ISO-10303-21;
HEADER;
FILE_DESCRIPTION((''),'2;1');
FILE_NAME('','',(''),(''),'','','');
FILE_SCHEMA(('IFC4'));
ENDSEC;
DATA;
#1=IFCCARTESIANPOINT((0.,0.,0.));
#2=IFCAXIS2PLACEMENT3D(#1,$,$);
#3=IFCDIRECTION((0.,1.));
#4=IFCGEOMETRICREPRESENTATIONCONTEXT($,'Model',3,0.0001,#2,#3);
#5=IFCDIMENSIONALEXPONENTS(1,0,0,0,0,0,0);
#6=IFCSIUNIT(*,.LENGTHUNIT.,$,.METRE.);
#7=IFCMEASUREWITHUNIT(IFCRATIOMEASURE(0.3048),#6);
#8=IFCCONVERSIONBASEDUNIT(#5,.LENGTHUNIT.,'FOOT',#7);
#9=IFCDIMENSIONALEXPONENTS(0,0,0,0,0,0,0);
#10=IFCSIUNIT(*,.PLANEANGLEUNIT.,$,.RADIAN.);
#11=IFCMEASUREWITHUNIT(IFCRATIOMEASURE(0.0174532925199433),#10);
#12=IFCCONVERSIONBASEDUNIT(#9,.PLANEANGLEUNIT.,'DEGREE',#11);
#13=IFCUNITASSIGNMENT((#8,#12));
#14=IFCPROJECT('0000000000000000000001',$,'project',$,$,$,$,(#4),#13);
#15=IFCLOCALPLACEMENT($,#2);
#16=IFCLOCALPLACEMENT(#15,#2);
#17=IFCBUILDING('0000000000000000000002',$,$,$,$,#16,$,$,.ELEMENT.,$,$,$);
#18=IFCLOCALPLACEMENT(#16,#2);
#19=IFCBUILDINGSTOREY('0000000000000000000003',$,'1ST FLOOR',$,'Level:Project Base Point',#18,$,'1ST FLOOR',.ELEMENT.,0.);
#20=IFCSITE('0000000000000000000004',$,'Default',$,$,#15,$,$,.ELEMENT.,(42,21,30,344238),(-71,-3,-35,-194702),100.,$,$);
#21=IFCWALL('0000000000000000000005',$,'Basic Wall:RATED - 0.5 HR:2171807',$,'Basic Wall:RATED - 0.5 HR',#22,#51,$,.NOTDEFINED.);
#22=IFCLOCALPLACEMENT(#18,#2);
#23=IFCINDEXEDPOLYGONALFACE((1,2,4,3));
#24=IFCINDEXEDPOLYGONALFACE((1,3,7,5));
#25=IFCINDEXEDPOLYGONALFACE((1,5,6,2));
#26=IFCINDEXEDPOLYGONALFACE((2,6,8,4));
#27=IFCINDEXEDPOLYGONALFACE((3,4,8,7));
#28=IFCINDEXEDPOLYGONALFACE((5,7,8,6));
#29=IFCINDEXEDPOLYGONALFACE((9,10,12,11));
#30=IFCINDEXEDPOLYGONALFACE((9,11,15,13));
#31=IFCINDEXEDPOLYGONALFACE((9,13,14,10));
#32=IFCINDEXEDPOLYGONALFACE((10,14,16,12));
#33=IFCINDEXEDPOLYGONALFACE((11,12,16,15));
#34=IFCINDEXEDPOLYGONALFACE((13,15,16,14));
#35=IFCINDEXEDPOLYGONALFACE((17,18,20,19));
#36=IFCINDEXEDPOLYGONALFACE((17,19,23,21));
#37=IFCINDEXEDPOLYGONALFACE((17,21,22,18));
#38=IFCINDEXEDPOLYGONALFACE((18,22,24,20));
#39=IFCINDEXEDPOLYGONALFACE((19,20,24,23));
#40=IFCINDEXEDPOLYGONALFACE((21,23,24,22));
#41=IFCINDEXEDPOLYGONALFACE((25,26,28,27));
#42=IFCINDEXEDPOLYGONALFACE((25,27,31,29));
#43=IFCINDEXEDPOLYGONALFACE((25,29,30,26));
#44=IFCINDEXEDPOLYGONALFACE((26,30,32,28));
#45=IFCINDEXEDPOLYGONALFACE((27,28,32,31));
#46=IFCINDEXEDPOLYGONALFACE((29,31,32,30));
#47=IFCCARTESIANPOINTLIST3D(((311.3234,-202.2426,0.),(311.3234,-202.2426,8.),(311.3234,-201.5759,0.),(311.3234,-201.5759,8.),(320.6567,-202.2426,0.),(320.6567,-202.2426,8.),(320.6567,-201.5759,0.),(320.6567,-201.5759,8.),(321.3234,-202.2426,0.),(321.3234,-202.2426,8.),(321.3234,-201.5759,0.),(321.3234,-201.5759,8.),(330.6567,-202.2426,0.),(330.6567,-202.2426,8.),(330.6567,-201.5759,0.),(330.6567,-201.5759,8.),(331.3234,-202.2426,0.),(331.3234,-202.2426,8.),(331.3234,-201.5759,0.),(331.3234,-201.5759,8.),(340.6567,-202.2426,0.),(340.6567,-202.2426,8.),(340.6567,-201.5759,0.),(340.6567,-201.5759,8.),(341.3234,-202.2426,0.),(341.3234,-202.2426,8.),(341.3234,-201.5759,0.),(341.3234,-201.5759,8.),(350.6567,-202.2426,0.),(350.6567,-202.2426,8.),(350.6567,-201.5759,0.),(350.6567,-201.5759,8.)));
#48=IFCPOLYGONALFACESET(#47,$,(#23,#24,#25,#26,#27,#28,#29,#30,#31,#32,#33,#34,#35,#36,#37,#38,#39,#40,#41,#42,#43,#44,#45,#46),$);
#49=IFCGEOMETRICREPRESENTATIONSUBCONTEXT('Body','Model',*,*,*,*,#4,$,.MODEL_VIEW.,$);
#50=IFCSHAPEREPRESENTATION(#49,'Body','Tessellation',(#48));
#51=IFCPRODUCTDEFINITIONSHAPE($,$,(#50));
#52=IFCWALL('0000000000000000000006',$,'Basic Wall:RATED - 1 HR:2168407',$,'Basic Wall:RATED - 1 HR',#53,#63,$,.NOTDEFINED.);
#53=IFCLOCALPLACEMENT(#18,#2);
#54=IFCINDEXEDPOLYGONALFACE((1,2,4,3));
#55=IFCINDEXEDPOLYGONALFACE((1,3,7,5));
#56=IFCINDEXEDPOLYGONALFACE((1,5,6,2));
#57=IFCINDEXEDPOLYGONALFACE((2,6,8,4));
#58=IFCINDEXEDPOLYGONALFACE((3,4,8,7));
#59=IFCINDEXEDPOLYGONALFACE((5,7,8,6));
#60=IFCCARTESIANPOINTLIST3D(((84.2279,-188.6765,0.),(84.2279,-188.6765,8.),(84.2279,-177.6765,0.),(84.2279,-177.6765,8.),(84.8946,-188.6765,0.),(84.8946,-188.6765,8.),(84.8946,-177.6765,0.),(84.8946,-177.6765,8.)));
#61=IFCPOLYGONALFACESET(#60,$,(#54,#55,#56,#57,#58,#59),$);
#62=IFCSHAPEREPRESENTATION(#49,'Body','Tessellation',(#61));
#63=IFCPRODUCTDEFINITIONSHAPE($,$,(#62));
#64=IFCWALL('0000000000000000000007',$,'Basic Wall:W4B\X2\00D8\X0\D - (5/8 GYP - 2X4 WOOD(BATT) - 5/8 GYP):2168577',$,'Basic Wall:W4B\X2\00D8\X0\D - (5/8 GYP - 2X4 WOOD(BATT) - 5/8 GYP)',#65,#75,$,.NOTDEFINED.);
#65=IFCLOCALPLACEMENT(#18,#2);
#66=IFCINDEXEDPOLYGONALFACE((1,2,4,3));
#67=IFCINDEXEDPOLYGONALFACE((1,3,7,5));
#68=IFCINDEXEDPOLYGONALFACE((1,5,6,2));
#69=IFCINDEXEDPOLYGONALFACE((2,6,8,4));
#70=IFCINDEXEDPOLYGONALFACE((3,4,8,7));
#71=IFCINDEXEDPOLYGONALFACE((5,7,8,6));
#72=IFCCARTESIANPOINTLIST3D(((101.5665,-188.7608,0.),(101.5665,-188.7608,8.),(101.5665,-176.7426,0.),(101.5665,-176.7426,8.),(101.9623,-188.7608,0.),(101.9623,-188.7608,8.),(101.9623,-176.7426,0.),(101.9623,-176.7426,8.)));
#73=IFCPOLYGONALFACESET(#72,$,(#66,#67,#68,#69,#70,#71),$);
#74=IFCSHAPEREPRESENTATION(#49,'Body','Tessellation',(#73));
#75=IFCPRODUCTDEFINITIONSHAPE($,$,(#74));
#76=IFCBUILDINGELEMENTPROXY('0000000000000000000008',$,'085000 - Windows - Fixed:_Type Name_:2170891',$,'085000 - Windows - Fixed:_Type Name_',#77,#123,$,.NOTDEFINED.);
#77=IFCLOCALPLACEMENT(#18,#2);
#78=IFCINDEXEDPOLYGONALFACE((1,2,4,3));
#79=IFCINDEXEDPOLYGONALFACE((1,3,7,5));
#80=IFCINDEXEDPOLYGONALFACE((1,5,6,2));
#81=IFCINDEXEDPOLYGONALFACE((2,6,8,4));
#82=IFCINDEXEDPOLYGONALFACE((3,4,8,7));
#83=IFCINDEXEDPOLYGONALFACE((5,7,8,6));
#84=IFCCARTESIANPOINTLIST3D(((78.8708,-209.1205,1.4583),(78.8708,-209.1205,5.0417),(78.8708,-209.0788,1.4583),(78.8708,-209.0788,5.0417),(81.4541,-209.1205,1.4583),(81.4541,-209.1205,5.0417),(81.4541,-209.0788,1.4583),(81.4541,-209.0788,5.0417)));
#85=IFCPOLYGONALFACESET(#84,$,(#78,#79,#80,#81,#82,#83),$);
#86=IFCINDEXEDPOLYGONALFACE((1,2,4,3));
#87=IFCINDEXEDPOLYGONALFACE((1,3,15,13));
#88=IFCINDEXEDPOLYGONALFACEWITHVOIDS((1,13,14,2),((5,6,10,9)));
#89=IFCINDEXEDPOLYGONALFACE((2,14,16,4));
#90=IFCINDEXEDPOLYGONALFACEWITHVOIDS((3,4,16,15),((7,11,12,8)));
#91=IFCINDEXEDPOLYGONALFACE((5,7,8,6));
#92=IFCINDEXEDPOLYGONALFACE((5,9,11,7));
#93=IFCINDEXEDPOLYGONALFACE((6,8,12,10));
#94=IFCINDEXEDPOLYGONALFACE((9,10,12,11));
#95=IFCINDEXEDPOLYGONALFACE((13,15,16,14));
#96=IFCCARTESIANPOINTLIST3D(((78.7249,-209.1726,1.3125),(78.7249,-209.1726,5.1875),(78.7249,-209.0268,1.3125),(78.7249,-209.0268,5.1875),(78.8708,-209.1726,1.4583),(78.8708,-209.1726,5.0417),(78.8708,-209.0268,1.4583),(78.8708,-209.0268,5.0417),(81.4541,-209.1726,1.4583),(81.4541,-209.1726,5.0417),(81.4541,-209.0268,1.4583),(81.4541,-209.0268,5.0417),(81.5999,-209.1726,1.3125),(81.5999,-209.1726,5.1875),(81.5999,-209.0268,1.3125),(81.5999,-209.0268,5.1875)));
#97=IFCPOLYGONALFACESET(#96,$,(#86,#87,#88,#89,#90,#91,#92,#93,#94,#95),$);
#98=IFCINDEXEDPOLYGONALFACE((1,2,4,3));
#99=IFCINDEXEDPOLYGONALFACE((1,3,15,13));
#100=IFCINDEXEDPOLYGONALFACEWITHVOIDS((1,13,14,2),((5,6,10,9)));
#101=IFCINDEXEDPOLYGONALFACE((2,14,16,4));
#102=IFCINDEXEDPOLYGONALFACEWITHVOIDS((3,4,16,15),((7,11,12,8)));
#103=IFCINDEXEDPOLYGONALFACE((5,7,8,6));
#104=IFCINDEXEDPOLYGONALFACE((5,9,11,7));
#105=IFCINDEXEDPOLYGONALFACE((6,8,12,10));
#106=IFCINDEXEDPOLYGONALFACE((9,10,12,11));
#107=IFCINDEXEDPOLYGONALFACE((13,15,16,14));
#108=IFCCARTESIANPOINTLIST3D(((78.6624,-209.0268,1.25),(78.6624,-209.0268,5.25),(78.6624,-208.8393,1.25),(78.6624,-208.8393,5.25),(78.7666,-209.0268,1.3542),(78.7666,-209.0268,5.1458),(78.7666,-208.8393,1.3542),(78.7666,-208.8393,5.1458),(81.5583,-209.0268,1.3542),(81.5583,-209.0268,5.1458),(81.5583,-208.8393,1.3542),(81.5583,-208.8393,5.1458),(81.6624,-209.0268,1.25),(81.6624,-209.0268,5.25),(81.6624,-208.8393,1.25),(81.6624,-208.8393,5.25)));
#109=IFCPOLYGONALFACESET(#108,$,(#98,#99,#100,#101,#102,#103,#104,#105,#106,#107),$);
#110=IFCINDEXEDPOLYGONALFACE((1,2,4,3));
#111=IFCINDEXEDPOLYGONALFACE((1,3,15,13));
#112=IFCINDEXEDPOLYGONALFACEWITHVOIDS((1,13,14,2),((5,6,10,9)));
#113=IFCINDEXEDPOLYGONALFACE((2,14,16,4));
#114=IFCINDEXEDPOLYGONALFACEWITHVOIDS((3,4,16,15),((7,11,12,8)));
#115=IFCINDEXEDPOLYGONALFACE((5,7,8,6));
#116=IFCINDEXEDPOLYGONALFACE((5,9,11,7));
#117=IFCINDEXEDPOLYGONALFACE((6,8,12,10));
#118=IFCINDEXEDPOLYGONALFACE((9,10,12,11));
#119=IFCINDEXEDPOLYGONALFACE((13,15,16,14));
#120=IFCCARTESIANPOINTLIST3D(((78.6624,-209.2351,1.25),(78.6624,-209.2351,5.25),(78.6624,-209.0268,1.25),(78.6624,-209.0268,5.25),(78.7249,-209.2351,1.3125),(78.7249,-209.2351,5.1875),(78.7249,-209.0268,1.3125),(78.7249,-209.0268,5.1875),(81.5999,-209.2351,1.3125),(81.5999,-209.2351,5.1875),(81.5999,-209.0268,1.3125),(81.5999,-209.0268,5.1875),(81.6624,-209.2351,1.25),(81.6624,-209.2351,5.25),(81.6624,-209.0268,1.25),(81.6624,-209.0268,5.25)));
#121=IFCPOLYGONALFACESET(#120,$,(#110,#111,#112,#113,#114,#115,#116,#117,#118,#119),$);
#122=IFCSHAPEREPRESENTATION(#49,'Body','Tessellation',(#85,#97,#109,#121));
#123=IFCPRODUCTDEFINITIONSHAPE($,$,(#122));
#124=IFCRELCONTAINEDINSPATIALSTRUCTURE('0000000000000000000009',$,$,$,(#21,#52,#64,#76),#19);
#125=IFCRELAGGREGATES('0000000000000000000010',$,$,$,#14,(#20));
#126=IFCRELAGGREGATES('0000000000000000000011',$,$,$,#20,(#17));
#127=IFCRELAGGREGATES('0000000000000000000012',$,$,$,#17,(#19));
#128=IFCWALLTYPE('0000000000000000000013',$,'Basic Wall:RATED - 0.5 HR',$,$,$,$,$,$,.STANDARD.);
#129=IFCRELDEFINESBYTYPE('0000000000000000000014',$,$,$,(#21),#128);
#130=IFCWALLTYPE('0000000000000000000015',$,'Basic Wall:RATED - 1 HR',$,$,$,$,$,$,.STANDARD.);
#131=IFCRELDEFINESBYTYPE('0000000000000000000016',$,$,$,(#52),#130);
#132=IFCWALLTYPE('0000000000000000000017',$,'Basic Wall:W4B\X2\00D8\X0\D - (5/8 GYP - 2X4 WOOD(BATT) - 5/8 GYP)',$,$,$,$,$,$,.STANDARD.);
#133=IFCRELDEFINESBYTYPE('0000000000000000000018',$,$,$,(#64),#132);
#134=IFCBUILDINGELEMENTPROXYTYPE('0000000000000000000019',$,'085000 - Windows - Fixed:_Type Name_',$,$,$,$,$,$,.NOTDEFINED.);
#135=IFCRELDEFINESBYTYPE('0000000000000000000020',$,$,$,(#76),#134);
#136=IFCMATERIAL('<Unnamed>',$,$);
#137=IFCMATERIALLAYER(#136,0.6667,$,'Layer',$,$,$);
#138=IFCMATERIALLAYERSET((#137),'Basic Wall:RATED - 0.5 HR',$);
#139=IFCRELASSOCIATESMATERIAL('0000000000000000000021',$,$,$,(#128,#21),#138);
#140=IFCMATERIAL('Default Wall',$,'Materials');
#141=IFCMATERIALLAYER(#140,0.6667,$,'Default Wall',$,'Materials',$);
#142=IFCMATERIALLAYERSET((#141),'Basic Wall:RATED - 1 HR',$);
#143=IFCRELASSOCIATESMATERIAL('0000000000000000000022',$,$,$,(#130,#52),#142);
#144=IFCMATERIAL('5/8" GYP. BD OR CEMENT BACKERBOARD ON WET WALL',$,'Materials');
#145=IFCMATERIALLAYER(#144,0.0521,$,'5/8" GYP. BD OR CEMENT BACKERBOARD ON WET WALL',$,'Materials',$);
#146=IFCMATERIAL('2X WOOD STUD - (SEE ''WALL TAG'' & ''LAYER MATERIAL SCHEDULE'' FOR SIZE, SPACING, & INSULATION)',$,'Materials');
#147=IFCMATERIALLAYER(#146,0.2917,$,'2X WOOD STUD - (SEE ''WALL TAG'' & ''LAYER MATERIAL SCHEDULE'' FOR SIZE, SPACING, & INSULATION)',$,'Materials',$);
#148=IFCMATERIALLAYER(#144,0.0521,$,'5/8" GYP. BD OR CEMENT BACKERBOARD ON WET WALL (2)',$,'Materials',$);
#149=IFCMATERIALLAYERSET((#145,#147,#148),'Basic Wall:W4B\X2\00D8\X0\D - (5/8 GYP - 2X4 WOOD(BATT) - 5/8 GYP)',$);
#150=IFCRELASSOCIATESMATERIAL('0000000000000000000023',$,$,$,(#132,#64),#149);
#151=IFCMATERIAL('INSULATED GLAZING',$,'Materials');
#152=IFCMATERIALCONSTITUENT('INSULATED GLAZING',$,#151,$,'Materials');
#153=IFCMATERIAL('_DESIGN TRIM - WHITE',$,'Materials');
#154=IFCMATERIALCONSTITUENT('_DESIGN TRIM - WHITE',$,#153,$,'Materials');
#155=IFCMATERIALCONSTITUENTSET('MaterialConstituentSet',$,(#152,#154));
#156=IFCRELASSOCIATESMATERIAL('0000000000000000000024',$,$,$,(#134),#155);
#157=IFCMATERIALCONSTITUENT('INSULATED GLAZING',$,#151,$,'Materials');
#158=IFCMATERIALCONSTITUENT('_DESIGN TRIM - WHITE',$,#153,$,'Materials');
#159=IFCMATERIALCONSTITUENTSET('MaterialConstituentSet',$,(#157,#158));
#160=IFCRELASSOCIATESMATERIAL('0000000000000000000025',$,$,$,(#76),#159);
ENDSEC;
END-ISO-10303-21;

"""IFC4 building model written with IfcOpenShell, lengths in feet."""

from ifc_helpers import new_model, entity, si_unit, converted_unit, direction, frame, frame_2d, origin, origin_2d_with_axis, place, context, subcontext, project, spatial, polyline, rectangle, outline, extrude, source, transform, mapped, material, layer, layer_set, layer_usage, constituent, constituent_set, type_object, type_shapes, element, save


model = new_model("IFC4")

# Units and contexts
model_context = context("Model", 3, precision=0.0001, world=origin(), true_north=direction((0.0, 1.0)))
body_context = subcontext(model_context, "Body", "Model", "MODEL_VIEW")
ifc_project = project(units=[converted_unit("LENGTHUNIT", "FOOT", entity("IfcRatioMeasure", 0.3048), si_unit("LENGTHUNIT", "METRE"), dimensions=[1, 0, 0, 0, 0, 0, 0]), converted_unit("PLANEANGLEUNIT", "DEGREE", entity("IfcRatioMeasure", 0.0174532925199433), si_unit("PLANEANGLEUNIT", "RADIAN"), dimensions=[0, 0, 0, 0, 0, 0, 0])], contexts=[model_context])

# Site, building, storey
site_placement = place(None, origin())
site = spatial("IfcSite", under=ifc_project, at=site_placement, Name="Default", CompositionType="ELEMENT", RefLatitude=(42, 21, 30, 344238), RefLongitude=(-71, -3, -35, -194702), RefElevation=100.0)
building_placement = place(site_placement, origin())
building = spatial("IfcBuilding", under=site, at=building_placement, CompositionType="ELEMENT")
storey_placement = place(building_placement, origin())
storey = spatial("IfcBuildingStorey", under=building, at=storey_placement, Name="1ST FLOOR", ObjectType="Level:Project Base Point", LongName="1ST FLOOR", CompositionType="ELEMENT", Elevation=0.0)

# Shared definitions
ifc_material_1 = material(Name="<Unnamed>")

# Shared definitions
ifc_layer_1 = layer(ifc_material_1, 0.6667, Name="Layer")
ifc_layer_set_1 = layer_set([ifc_layer_1], Name="Basic Wall:RATED - 0.5 HR")
wall_type_1 = type_object("IfcWallType", Name="Basic Wall:RATED - 0.5 HR", PredefinedType="STANDARD", material=ifc_layer_set_1)

# Wall, openings
ifc_layer_usage_1 = layer_usage(ifc_layer_set_1, "AXIS2", "NEGATIVE", 0.3333)
wall_1_placement = place(storey_placement, frame((311.3234, -201.9092, 0.0)))
wall_1 = element("IfcWall", 1, at=wall_1_placement, inside=storey, type_object=wall_type_1, material=ifc_layer_usage_1, Name="Basic Wall:RATED - 0.5 HR:2171807", ObjectType="Basic Wall:RATED - 0.5 HR", PredefinedType="NOTDEFINED", context=body_context, shape_type="SweptSolid", body=[
    extrude(rectangle(XDim=39.3333, YDim=0.6667, at=frame_2d((19.6667, 0.0), x_axis=(-1.0, 0.0))), origin(), (0.0, 0.0, 1.0), 8.0),
])
opening_1_placement = place(storey_placement, frame((311.3234, -201.9092, 0.0)))
element("IfcOpeningElement", 2, at=opening_1_placement, cuts=wall_1, PredefinedType="OPENING", context=body_context, shape_type="SweptSolid", body=[
    extrude(rectangle(XDim=8.0, YDim=0.6667, at=frame_2d((0.0, 0.0), x_axis=(1.0, 0.0))), frame((29.3333, 0.0, 4.0), z_axis=(1.0, 0.0, 0.0), x_axis=(0.0, 0.0, -1.0)), (0.0, 0.0, 1.0), 0.6667),
])
opening_2_placement = place(storey_placement, frame((311.3234, -201.9092, 0.0)))
element("IfcOpeningElement", 3, at=opening_2_placement, cuts=wall_1, PredefinedType="OPENING", context=body_context, shape_type="SweptSolid", body=[
    extrude(rectangle(XDim=8.0, YDim=0.6667, at=frame_2d((0.0, 0.0), x_axis=(1.0, 0.0))), frame((19.3333, 0.0, 4.0), z_axis=(1.0, 0.0, 0.0), x_axis=(0.0, 0.0, -1.0)), (0.0, 0.0, 1.0), 0.6667),
])
opening_3_placement = place(storey_placement, frame((311.3234, -201.9092, 0.0)))
element("IfcOpeningElement", 4, at=opening_3_placement, cuts=wall_1, PredefinedType="OPENING", context=body_context, shape_type="SweptSolid", body=[
    extrude(rectangle(XDim=8.0, YDim=0.6667, at=frame_2d((0.0, 0.0), x_axis=(1.0, 0.0))), frame((9.3333, 0.0, 4.0), z_axis=(1.0, 0.0, 0.0), x_axis=(0.0, 0.0, -1.0)), (0.0, 0.0, 1.0), 0.6667),
])

# Walls
ifc_material_2 = material(Name="Default Wall", Category="Materials")
ifc_layer_2 = layer(ifc_material_2, 0.6667, Name="Default Wall", Category="Materials")
ifc_layer_set_2 = layer_set([ifc_layer_2], Name="Basic Wall:RATED - 1 HR")
ifc_layer_usage_2 = layer_usage(ifc_layer_set_2, "AXIS2", "POSITIVE", -0.3333)
wall_type_2 = type_object("IfcWallType", Name="Basic Wall:RATED - 1 HR", PredefinedType="STANDARD", material=ifc_layer_set_2)
wall_2_placement = place(storey_placement, frame((84.5613, -188.6765, 0.0), z_axis=(0.0, 0.0, 1.0), x_axis=(0.0, 1.0, 0.0)))
element("IfcWall", 5, at=wall_2_placement, inside=storey, type_object=wall_type_2, material=ifc_layer_usage_2, Name="Basic Wall:RATED - 1 HR:2168407", ObjectType="Basic Wall:RATED - 1 HR", PredefinedType="NOTDEFINED", context=body_context, shape_type="SweptSolid", body=[
    extrude(rectangle(XDim=11.0, YDim=0.6667, at=frame_2d((5.5, 0.0), x_axis=(-1.0, 0.0))), origin(), (0.0, 0.0, 1.0), 8.0),
])
ifc_material_3 = material(Name="5/8\" GYP. BD OR CEMENT BACKERBOARD ON WET WALL", Category="Materials")
ifc_layer_3 = layer(ifc_material_3, 0.0521, Name="5/8\" GYP. BD OR CEMENT BACKERBOARD ON WET WALL", Category="Materials")
ifc_material_4 = material(Name="2X WOOD STUD - (SEE 'WALL TAG' & 'LAYER MATERIAL SCHEDULE' FOR SIZE, SPACING, & INSULATION)", Category="Materials")
ifc_layer_4 = layer(ifc_material_4, 0.2917, Name="2X WOOD STUD - (SEE 'WALL TAG' & 'LAYER MATERIAL SCHEDULE' FOR SIZE, SPACING, & INSULATION)", Category="Materials")
ifc_layer_5 = layer(ifc_material_3, 0.0521, Name="5/8\" GYP. BD OR CEMENT BACKERBOARD ON WET WALL (2)", Category="Materials")
ifc_layer_set_3 = layer_set([ifc_layer_3, ifc_layer_4, ifc_layer_5], Name="Basic Wall:W4BØD - (5/8 GYP - 2X4 WOOD(BATT) - 5/8 GYP)")
ifc_layer_usage_3 = layer_usage(ifc_layer_set_3, "AXIS2", "NEGATIVE", 0.1979)
wall_type_3 = type_object("IfcWallType", Name="Basic Wall:W4BØD - (5/8 GYP - 2X4 WOOD(BATT) - 5/8 GYP)", PredefinedType="STANDARD", material=ifc_layer_set_3)
wall_3_placement = place(storey_placement, frame((101.7644, -176.7426, 0.0), z_axis=(0.0, 0.0, 1.0), x_axis=(0.0, -1.0, 0.0)))
element("IfcWall", 6, at=wall_3_placement, inside=storey, type_object=wall_type_3, material=ifc_layer_usage_3, Name="Basic Wall:W4BØD - (5/8 GYP - 2X4 WOOD(BATT) - 5/8 GYP):2168577", ObjectType="Basic Wall:W4BØD - (5/8 GYP - 2X4 WOOD(BATT) - 5/8 GYP)", PredefinedType="NOTDEFINED", context=body_context, shape_type="SweptSolid", body=[
    extrude(rectangle(XDim=12.0182, YDim=0.3958, at=frame_2d((6.0091, 0.0), x_axis=(-1.0, 0.0))), origin(), (0.0, 0.0, 1.0), 8.0),
])

# Shared definitions
ifc_material_5 = material(Name="_DESIGN TRIM - WHITE", Category="Materials")

# Building element proxy
ifc_material_6 = material(Name="INSULATED GLAZING", Category="Materials")
ifc_constituent_1 = constituent(ifc_material_6, Name="INSULATED GLAZING", Category="Materials")
ifc_constituent_2 = constituent(ifc_material_5, Name="_DESIGN TRIM - WHITE", Category="Materials")
ifc_constituent_set_1 = constituent_set(constituents=[ifc_constituent_1, ifc_constituent_2], Name="MaterialConstituentSet")
ifc_constituent_3 = constituent(ifc_material_6, Name="INSULATED GLAZING", Category="Materials")
ifc_constituent_4 = constituent(ifc_material_5, Name="_DESIGN TRIM - WHITE", Category="Materials")
ifc_constituent_set_2 = constituent_set(constituents=[ifc_constituent_3, ifc_constituent_4], Name="MaterialConstituentSet")
building_element_proxy_type = type_object("IfcBuildingElementProxyType", Name="085000 - Windows - Fixed:_Type Name_", PredefinedType="NOTDEFINED", material=ifc_constituent_set_2)
shared_shape_1 = source(origin(), body_context, "Body", "SweptSolid", [
    extrude(rectangle(XDim=0.0417, YDim=2.5833, at=origin_2d_with_axis()), frame((1.5, 0.2604, 0.2083), z_axis=(0.0, 0.0, 1.0), x_axis=(0.0, 1.0, 0.0)), (0.0, 0.0, 1.0), 3.5833),
    extrude(outline(polyline([(-1.4375, -1.9375), (1.4375, -1.9375), (1.4375, 1.9375), (-1.4375, 1.9375), (-1.4375, -1.9375)]), holes=[polyline([(-1.2917, -1.7917), (-1.2917, 1.7917), (1.2917, 1.7917), (1.2917, -1.7917), (-1.2917, -1.7917)])]), frame((1.5, 0.1875, 2.0), z_axis=(0.0, 1.0, 0.0), x_axis=(1.0, 0.0, 0.0)), (0.0, 0.0, 1.0), 0.1458),
    extrude(outline(polyline([(-1.5, -2.0), (1.5, -2.0), (1.5, 2.0), (-1.5, 2.0), (-1.5, -2.0)]), holes=[polyline([(-1.3958, -1.8958), (-1.3958, 1.8958), (1.3958, 1.8958), (1.3958, -1.8958), (-1.3958, -1.8958)])]), frame((1.5, 0.0, 2.0), z_axis=(0.0, 1.0, 0.0), x_axis=(1.0, 0.0, 0.0)), (0.0, 0.0, 1.0), 0.1875),
    extrude(outline(polyline([(-2.0, -1.5), (2.0, -1.5), (2.0, 1.5), (-2.0, 1.5), (-2.0, -1.5)]), holes=[polyline([(-1.9375, -1.4375), (-1.9375, 1.4375), (1.9375, 1.4375), (1.9375, -1.4375), (-1.9375, -1.4375)])]), frame((1.5, 0.1875, 2.0), z_axis=(0.0, 1.0, 0.0), x_axis=(0.0, 0.0, -1.0)), (0.0, 0.0, 1.0), 0.2083),
])
type_shapes(building_element_proxy_type, [shared_shape_1])
proxy_placement = place(storey_placement, frame((81.6624, -208.8393, 1.25), z_axis=(0.0, 0.0, 1.0), x_axis=(-1.0, 0.0, 0.0)))
element("IfcBuildingElementProxy", 7, at=proxy_placement, inside=storey, type_object=building_element_proxy_type, material=ifc_constituent_set_1, Name="085000 - Windows - Fixed:_Type Name_:2170891", ObjectType="085000 - Windows - Fixed:_Type Name_", PredefinedType="NOTDEFINED", context=body_context, shape_type="MappedRepresentation", body=[
    mapped(shared_shape_1, transform((0.0, 0.0, 0.0), scale=1.0)),
])

save(model, "model.ifc")
